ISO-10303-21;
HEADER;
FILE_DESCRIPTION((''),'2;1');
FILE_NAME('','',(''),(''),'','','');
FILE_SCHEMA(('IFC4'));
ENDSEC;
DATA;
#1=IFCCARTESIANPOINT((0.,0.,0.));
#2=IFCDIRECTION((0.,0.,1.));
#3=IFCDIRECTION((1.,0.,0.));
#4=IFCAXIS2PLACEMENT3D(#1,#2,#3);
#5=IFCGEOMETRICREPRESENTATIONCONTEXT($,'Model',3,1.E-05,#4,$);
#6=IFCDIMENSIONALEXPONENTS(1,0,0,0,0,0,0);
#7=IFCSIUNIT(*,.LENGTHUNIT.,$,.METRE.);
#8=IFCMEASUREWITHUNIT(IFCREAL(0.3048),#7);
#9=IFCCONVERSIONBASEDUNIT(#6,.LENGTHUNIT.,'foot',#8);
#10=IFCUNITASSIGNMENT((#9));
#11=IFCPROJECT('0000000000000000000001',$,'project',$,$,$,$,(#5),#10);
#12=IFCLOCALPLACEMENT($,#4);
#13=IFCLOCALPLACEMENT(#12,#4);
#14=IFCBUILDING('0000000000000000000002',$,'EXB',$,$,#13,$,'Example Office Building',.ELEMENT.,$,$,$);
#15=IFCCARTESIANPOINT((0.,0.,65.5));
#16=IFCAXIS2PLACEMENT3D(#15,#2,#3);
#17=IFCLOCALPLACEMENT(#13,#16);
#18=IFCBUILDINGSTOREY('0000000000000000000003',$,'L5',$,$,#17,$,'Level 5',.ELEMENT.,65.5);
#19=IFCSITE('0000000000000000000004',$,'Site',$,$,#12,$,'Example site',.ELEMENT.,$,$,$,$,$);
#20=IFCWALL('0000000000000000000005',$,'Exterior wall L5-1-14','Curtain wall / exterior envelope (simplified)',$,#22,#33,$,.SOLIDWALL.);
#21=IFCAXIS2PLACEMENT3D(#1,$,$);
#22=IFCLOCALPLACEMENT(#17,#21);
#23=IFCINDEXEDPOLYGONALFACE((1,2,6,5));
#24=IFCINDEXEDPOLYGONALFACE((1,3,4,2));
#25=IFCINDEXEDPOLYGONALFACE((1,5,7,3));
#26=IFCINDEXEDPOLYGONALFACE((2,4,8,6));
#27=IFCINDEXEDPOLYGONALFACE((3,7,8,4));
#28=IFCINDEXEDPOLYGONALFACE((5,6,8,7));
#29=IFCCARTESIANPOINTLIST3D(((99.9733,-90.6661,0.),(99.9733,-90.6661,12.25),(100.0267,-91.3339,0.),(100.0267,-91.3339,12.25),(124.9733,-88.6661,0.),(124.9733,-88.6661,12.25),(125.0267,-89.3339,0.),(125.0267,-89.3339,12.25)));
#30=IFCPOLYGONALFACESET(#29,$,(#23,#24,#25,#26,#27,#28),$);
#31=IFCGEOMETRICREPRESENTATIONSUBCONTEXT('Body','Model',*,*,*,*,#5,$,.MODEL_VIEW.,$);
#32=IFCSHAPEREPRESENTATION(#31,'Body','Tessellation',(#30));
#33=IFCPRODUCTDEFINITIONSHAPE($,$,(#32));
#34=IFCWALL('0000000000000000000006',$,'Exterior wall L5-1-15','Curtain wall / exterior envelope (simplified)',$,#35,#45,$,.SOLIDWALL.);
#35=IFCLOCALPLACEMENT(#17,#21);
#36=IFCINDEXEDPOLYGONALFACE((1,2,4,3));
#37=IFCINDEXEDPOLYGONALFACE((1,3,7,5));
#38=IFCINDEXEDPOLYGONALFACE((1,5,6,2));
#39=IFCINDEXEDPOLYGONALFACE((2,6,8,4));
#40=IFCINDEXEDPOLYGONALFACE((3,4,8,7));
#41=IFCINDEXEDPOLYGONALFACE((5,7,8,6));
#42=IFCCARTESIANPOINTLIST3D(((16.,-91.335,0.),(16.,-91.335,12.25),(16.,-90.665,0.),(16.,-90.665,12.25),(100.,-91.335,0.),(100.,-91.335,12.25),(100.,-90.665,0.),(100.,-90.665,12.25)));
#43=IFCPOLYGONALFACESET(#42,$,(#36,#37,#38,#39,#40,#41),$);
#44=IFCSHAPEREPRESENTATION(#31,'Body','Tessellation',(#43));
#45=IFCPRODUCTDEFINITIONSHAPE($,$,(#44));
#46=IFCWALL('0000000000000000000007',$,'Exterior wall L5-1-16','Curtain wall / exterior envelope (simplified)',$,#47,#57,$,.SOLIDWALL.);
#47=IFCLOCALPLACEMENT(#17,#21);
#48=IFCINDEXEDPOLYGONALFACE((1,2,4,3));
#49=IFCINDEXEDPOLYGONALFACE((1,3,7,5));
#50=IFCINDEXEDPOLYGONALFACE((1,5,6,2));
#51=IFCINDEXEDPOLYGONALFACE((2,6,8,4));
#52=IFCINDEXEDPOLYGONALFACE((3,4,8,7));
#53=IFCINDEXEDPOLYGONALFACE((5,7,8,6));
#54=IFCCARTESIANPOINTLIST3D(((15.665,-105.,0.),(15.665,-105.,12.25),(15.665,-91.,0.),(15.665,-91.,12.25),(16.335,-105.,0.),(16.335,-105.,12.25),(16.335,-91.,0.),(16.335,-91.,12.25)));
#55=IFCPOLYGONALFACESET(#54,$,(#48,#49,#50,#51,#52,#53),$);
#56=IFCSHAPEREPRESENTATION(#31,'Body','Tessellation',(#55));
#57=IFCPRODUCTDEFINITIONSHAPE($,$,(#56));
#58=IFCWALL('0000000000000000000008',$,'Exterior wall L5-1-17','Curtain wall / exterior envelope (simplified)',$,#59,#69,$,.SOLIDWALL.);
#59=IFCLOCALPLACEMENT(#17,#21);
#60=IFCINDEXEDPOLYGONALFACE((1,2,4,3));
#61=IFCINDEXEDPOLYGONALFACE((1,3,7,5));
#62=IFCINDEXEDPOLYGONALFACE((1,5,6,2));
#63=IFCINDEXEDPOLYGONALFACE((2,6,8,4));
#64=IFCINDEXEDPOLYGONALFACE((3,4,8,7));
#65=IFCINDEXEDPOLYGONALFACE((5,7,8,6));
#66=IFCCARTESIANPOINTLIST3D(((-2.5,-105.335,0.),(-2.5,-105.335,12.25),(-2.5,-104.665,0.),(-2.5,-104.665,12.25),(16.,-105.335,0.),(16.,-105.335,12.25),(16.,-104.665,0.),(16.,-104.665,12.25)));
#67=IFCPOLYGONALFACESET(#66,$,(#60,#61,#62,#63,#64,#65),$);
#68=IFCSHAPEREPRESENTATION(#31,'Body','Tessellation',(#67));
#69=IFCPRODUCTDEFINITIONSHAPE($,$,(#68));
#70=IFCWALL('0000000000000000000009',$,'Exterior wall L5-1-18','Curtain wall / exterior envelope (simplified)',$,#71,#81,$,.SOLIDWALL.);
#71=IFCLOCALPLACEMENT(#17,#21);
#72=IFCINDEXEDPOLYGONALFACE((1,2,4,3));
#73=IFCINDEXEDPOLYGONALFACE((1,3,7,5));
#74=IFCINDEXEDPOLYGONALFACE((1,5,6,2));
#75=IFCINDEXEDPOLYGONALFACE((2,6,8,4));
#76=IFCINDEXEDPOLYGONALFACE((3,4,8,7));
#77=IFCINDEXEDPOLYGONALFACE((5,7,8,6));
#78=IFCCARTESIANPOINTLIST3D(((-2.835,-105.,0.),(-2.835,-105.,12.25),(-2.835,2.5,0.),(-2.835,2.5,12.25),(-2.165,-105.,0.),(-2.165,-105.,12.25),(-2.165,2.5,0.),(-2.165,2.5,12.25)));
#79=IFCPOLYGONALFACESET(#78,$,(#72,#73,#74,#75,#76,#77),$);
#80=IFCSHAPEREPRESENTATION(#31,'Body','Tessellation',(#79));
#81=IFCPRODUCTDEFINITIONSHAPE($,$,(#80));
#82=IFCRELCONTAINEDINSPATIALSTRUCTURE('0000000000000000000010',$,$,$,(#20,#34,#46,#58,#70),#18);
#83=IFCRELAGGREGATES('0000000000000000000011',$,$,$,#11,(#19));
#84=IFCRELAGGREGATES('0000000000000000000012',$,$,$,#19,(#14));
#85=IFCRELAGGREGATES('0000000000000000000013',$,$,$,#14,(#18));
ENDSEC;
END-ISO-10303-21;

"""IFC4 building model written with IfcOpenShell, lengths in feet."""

from ifc_helpers import new_model, entity, si_unit, converted_unit, frame, frame_2d, origin, origin_with_axes, place, context, subcontext, project, spatial, rectangle, extrude, element, save


model = new_model("IFC4")

# Units and contexts
model_context = context("Model", 3, precision=1e-05, world=origin_with_axes())
body_context = subcontext(model_context, "Body", "Model", "MODEL_VIEW")
ifc_project = project(units=[converted_unit("LENGTHUNIT", "foot", entity("IfcReal", 0.3048), si_unit("LENGTHUNIT", "METRE"), dimensions=[1, 0, 0, 0, 0, 0, 0])], contexts=[model_context])

# Site, building, storey
site_placement = place(None, origin_with_axes())
site = spatial("IfcSite", under=ifc_project, at=site_placement, Name="Site", LongName="Example site", CompositionType="ELEMENT")
building_placement = place(site_placement, origin_with_axes())
building = spatial("IfcBuilding", under=site, at=building_placement, Name="EXB", LongName="Example Office Building", CompositionType="ELEMENT")
storey_placement = place(building_placement, frame((0.0, 0.0, 65.5), z_axis=(0.0, 0.0, 1.0), x_axis=(1.0, 0.0, 0.0)))
storey = spatial("IfcBuildingStorey", under=building, at=storey_placement, Name="L5", LongName="Level 5", CompositionType="ELEMENT", Elevation=65.5)

# Walls
wall_1_placement = place(storey_placement, frame((125.0, -89.0, 0.0), z_axis=(0.0, 0.0, 1.0), x_axis=(-0.996815, -0.079745, 0.0)))
element("IfcWall", 1, at=wall_1_placement, inside=storey, Name="Exterior wall L5-1-14", Description="Curtain wall / exterior envelope (simplified)", PredefinedType="SOLIDWALL", context=body_context, shape_type="SweptSolid", body=[
    extrude(rectangle(XDim=25.0799, YDim=0.67, at=frame_2d((12.5399, 0.0))), origin(), (0.0, 0.0, 1.0), 12.25),
])
wall_2_placement = place(storey_placement, frame((100.0, -91.0, 0.0), z_axis=(0.0, 0.0, 1.0), x_axis=(-1.0, 0.0, 0.0)))
element("IfcWall", 2, at=wall_2_placement, inside=storey, Name="Exterior wall L5-1-15", Description="Curtain wall / exterior envelope (simplified)", PredefinedType="SOLIDWALL", context=body_context, shape_type="SweptSolid", body=[
    extrude(rectangle(XDim=84.0, YDim=0.67, at=frame_2d((42.0, 0.0))), origin(), (0.0, 0.0, 1.0), 12.25),
])
wall_3_placement = place(storey_placement, frame((16.0, -91.0, 0.0), z_axis=(0.0, 0.0, 1.0), x_axis=(0.0, -1.0, 0.0)))
element("IfcWall", 3, at=wall_3_placement, inside=storey, Name="Exterior wall L5-1-16", Description="Curtain wall / exterior envelope (simplified)", PredefinedType="SOLIDWALL", context=body_context, shape_type="SweptSolid", body=[
    extrude(rectangle(XDim=14.0, YDim=0.67, at=frame_2d((7.0, 0.0))), origin(), (0.0, 0.0, 1.0), 12.25),
])
wall_4_placement = place(storey_placement, frame((16.0, -105.0, 0.0), z_axis=(0.0, 0.0, 1.0), x_axis=(-1.0, 0.0, 0.0)))
element("IfcWall", 4, at=wall_4_placement, inside=storey, Name="Exterior wall L5-1-17", Description="Curtain wall / exterior envelope (simplified)", PredefinedType="SOLIDWALL", context=body_context, shape_type="SweptSolid", body=[
    extrude(rectangle(XDim=18.5, YDim=0.67, at=frame_2d((9.25, 0.0))), origin(), (0.0, 0.0, 1.0), 12.25),
])
wall_5_placement = place(storey_placement, frame((-2.5, -105.0, 0.0), z_axis=(0.0, 0.0, 1.0), x_axis=(0.0, 1.0, 0.0)))
element("IfcWall", 5, at=wall_5_placement, inside=storey, Name="Exterior wall L5-1-18", Description="Curtain wall / exterior envelope (simplified)", PredefinedType="SOLIDWALL", context=body_context, shape_type="SweptSolid", body=[
    extrude(rectangle(XDim=107.5, YDim=0.67, at=frame_2d((53.75, 0.0))), origin(), (0.0, 0.0, 1.0), 12.25),
])

save(model, "model.ifc")
